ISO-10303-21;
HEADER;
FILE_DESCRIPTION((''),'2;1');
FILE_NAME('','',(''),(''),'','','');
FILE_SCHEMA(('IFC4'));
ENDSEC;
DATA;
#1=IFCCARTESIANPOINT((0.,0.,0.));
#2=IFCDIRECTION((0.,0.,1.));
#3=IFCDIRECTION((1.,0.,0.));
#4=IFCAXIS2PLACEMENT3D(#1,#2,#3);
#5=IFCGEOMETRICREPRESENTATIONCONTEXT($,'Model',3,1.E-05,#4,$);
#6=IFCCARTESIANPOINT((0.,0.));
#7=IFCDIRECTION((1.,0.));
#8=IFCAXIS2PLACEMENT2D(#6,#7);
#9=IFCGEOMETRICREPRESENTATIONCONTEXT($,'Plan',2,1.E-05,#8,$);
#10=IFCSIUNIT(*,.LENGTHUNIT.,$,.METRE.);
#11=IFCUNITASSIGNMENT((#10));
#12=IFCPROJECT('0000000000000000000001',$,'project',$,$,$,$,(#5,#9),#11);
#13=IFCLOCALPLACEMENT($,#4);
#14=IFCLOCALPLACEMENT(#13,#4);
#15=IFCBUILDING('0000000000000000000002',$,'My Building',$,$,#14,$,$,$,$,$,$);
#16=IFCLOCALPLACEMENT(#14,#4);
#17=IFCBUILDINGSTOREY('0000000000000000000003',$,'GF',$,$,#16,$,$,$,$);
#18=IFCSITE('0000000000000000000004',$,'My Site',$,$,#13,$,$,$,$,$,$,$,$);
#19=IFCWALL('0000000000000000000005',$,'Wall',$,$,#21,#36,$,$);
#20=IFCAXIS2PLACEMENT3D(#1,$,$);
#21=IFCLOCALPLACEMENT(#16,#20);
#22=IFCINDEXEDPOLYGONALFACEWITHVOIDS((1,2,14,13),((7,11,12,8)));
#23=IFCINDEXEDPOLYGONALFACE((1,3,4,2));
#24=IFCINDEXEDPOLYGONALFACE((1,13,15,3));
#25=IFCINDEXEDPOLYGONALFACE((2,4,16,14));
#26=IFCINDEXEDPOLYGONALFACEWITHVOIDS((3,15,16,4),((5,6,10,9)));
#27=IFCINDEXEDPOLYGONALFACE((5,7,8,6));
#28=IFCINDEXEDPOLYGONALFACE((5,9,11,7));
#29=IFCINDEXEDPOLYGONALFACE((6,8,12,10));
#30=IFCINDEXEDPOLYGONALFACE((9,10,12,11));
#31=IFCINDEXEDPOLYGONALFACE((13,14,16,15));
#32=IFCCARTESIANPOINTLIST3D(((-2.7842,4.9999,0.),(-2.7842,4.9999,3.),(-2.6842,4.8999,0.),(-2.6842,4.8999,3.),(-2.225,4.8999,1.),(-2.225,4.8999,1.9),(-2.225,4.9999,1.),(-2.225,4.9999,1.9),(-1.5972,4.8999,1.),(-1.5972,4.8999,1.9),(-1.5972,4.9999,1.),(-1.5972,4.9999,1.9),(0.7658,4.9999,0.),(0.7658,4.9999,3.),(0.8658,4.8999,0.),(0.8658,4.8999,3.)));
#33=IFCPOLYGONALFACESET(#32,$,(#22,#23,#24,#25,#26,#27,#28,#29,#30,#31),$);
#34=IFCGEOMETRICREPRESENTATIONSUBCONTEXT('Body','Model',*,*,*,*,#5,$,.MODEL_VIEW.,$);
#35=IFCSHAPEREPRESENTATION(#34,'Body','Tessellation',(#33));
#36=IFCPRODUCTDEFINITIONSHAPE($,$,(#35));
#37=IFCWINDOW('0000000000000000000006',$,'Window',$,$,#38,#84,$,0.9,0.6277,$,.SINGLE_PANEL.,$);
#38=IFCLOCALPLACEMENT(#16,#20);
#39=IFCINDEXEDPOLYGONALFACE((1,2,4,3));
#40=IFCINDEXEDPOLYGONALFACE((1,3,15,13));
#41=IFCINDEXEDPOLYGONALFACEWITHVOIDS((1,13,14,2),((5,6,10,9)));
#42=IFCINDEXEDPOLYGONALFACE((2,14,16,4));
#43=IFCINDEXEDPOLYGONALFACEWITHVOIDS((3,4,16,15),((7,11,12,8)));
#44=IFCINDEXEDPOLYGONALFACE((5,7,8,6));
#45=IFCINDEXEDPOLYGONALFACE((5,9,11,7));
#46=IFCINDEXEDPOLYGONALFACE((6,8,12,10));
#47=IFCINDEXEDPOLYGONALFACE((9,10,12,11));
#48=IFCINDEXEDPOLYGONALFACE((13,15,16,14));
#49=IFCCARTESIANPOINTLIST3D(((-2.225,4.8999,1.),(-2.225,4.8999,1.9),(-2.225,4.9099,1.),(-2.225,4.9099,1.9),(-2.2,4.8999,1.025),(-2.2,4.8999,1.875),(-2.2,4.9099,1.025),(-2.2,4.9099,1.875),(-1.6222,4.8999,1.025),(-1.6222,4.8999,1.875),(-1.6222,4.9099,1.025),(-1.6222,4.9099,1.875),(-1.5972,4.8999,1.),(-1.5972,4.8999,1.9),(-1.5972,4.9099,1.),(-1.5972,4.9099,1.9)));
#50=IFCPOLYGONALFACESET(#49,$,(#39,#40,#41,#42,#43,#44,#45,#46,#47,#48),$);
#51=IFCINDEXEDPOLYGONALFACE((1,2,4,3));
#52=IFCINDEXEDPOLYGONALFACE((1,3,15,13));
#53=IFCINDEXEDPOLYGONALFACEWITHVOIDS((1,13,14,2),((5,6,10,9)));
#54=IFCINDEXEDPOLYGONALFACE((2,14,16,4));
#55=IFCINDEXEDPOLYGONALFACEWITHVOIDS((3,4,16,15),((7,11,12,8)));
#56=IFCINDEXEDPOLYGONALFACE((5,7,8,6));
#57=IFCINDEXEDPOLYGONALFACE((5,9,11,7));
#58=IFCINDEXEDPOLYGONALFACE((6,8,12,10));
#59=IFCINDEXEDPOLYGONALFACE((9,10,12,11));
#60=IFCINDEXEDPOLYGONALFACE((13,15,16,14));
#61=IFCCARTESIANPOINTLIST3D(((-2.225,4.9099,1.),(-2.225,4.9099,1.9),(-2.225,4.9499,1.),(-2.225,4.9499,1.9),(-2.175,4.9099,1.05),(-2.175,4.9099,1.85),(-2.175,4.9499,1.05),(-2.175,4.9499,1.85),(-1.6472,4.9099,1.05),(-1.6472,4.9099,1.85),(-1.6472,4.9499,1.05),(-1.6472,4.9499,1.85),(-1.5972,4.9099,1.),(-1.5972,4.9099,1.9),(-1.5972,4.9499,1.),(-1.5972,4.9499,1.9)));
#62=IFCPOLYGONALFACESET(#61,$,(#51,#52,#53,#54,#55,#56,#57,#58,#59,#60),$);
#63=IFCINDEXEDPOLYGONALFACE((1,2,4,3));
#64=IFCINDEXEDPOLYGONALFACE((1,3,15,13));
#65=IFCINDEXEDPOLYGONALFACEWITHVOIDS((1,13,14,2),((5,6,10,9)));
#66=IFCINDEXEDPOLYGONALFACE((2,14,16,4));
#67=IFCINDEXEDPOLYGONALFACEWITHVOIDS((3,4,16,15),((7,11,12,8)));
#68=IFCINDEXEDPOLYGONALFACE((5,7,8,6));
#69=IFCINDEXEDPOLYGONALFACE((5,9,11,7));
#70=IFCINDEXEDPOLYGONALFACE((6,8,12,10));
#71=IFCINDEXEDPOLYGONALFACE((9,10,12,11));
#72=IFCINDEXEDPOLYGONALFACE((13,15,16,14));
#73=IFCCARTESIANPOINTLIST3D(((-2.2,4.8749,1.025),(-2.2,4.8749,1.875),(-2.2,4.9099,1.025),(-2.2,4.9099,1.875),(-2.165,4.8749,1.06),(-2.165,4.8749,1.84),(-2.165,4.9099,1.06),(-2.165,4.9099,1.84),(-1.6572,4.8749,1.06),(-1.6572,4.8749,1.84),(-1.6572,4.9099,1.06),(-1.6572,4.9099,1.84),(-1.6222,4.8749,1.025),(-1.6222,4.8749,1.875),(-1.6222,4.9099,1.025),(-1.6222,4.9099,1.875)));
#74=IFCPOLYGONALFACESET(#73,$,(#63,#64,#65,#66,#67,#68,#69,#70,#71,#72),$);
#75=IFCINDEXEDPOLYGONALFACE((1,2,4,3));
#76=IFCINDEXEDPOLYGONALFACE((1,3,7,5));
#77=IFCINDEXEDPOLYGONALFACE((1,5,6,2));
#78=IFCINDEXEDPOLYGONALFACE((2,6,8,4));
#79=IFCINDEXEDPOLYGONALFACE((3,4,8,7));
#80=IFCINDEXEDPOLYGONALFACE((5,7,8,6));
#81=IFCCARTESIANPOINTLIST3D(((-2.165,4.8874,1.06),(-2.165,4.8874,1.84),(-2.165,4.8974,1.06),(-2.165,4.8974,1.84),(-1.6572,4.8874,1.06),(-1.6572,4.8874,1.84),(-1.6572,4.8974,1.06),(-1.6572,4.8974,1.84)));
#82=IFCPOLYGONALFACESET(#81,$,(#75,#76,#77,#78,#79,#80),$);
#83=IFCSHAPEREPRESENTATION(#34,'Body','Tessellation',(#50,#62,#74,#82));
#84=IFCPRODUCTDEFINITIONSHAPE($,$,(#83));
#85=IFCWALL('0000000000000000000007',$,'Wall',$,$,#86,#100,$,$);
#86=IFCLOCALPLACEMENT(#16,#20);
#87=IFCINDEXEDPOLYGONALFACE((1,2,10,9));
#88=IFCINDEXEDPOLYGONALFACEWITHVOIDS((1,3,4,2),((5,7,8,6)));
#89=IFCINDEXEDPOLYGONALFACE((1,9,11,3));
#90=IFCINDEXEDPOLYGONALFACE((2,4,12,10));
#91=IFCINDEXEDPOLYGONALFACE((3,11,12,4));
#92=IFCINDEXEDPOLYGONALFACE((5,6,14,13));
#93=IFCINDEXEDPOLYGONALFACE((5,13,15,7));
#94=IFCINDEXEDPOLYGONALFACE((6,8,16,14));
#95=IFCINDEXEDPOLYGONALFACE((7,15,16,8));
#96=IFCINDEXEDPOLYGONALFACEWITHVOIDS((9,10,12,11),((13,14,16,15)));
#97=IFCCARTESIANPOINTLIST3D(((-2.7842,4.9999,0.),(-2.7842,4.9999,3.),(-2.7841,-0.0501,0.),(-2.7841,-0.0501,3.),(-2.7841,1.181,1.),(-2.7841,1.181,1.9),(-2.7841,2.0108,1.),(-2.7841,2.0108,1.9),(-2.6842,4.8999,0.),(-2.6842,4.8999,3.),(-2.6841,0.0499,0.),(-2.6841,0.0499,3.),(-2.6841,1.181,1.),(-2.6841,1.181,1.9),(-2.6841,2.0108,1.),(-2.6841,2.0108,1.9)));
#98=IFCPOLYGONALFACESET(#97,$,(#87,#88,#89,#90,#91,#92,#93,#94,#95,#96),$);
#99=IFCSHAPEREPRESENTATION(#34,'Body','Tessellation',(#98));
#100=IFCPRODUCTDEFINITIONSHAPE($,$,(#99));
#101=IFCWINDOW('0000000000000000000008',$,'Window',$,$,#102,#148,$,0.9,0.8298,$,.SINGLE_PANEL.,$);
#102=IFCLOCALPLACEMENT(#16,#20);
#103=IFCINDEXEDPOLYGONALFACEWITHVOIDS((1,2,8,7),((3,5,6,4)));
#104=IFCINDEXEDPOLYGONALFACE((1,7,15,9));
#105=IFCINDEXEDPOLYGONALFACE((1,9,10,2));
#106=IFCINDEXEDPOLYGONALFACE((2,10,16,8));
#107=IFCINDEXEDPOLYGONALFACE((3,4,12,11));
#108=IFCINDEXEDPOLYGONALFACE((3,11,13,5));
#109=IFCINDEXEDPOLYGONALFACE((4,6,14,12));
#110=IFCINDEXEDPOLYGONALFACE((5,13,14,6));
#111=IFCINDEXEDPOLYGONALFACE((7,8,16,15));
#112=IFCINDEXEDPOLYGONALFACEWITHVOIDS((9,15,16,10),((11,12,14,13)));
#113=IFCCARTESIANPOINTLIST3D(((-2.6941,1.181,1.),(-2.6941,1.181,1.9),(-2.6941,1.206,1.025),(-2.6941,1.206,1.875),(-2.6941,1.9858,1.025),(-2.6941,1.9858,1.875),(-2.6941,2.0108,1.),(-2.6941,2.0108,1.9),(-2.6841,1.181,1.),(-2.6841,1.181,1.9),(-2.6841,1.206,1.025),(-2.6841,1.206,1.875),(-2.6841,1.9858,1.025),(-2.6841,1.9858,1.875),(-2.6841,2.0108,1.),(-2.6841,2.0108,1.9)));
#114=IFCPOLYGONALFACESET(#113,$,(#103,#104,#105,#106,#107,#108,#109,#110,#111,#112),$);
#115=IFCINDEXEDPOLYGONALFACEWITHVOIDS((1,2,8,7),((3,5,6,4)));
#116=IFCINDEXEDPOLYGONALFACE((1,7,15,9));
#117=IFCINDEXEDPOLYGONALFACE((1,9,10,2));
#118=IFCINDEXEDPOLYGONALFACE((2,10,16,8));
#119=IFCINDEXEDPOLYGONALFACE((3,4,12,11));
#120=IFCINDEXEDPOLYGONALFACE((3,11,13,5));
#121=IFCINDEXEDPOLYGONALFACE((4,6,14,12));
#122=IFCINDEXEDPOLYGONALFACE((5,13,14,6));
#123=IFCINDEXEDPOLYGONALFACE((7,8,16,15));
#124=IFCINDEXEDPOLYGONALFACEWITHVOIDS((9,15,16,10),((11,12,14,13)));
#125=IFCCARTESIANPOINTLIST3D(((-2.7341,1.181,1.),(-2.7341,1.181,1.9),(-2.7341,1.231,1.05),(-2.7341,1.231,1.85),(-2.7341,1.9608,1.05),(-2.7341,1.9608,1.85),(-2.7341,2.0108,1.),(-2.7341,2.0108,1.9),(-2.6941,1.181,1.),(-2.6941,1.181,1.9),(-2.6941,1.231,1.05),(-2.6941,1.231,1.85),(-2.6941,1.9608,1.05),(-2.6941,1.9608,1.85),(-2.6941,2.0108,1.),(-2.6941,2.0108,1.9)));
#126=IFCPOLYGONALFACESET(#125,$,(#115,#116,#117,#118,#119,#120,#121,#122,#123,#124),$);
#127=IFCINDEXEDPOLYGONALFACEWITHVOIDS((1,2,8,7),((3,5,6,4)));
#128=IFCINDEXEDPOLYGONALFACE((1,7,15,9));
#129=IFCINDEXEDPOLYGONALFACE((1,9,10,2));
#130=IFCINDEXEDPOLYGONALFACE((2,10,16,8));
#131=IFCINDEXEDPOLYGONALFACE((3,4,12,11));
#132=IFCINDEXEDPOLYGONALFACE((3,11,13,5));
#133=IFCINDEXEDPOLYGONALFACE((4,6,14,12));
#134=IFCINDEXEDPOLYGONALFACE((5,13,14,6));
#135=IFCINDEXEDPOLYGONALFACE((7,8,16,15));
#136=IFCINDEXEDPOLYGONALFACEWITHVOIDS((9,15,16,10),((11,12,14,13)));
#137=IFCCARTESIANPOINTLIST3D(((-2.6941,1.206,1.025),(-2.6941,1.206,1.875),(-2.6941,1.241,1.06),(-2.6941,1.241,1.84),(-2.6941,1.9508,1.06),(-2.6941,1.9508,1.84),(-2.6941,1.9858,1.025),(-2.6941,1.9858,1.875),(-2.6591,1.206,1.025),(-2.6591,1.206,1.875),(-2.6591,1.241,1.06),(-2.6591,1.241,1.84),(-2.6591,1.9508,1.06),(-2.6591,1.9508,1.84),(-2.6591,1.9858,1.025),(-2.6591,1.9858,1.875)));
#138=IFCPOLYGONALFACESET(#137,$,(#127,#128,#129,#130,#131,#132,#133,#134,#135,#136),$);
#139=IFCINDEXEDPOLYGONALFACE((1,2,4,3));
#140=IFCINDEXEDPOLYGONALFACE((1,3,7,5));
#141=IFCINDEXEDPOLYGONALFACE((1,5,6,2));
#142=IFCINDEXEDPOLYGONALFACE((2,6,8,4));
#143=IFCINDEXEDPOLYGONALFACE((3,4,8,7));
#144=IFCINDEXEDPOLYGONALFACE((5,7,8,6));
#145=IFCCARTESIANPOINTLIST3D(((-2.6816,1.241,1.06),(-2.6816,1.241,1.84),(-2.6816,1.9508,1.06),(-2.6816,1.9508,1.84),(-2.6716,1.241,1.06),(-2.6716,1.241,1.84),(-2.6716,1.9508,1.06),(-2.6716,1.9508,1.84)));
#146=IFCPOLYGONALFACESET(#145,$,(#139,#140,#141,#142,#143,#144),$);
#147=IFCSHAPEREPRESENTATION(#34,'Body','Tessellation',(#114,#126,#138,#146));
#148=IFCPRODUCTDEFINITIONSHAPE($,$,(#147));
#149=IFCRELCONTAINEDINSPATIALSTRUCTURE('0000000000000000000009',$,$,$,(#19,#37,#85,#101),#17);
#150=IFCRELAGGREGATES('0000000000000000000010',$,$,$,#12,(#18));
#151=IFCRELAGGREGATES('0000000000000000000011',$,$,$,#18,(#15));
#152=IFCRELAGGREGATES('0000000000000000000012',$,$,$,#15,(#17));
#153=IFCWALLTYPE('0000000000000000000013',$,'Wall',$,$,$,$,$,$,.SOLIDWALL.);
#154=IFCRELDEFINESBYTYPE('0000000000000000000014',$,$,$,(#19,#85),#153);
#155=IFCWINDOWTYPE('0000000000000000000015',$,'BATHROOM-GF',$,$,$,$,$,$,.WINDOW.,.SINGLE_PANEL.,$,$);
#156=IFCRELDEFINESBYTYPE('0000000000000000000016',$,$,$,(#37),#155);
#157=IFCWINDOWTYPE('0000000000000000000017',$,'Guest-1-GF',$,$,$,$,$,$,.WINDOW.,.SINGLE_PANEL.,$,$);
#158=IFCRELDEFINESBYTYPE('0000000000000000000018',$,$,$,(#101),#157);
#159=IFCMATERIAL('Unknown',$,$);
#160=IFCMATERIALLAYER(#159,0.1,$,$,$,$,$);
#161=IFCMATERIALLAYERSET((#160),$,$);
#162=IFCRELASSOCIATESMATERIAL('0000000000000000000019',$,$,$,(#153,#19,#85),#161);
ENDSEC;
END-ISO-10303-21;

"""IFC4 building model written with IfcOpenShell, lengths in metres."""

from ifc_helpers import new_model, entity, si_unit, frame, origin_with_axes, origin_2d_with_axis, place, context, subcontext, project, spatial, line, indexed_curve, outline, extrude, shape, source, transform, mapped, material, layer, layer_set, layer_usage, type_object, type_shapes, element, fill, save


model = new_model("IFC4")

# Units and contexts
model_context = context("Model", 3, precision=1e-05, world=origin_with_axes())
plan_context = context("Plan", 2, precision=1e-05, world=origin_2d_with_axis())
body_context_1 = subcontext(model_context, "Body", "Model", "MODEL_VIEW")
body_context_2 = subcontext(plan_context, "Body", "Plan", "PLAN_VIEW")
ifc_project = project(units=[si_unit("LENGTHUNIT", "METRE")], contexts=[model_context, plan_context])

# Site, building, storey
site_placement = place(None, origin_with_axes())
site = spatial("IfcSite", under=ifc_project, at=site_placement, Name="My Site")
building_placement = place(site_placement, origin_with_axes())
building = spatial("IfcBuilding", under=site, at=building_placement, Name="My Building")
storey_placement = place(building_placement, origin_with_axes())
storey = spatial("IfcBuildingStorey", under=building, at=storey_placement, Name="GF")

# Shared definitions
ifc_material_1 = material(Name="Unknown")

# Shared definitions
ifc_layer_1 = layer(ifc_material_1, 0.1)
ifc_layer_set_1 = layer_set([ifc_layer_1])
wall_type = type_object("IfcWallType", Name="Wall", PredefinedType="SOLIDWALL", material=ifc_layer_set_1)

# Walls, openings, windows
ifc_layer_usage_1 = layer_usage(ifc_layer_set_1, "AXIS2", "POSITIVE", 0.0)
wall_1_placement = place(storey_placement, frame((0.7658, 4.9999, 0.0), z_axis=(0.0, 0.0, 1.0), x_axis=(-1.0, 0.0, 0.0)))
wall_1 = element("IfcWall", 1, at=wall_1_placement, inside=storey, type_object=wall_type, material=ifc_layer_usage_1, Name="Wall", context=body_context_1, shape_type="SweptSolid", body=[
    extrude(outline(indexed_curve([(0.0, 0.0), (-0.1, 0.1), (3.45, 0.1), (3.55, 0.0)], segments=[line(1, 2, 3, 4, 1)])), origin_with_axes(), (0.0, 0.0, 1.0), 3.0),
])
shared_shape_1 = source(origin_with_axes(), body_context_1, "Body", "SweptSolid", [
    extrude(outline(indexed_curve([(0.0, 0.0), (0.6277, 0.0), (0.6277, 0.9), (0.0, 0.9)], segments=[line(1, 2, 3, 4, 1)])), frame((0.0, -0.6, 0.0), z_axis=(0.0, -1.0, 0.0), x_axis=(1.0, 0.0, 0.0)), (0.0, 0.0, -1.0), 1.2),
])
opening_1_placement = place(wall_1_placement, frame((2.3631, 0.0, 1.0), z_axis=(0.0, 0.0, 1.0), x_axis=(1.0, 0.0, 0.0)))
opening_1 = element("IfcOpeningElement", 2, at=opening_1_placement, cuts=wall_1, PredefinedType="OPENING", context=body_context_1, shape_type="MappedRepresentation", body=[
    mapped(shared_shape_1, transform((0.0, 0.0, 0.0), x_axis=(1.0, 0.0, 0.0), y_axis=(0.0, 1.0, 0.0), z_axis=(0.0, 0.0, 1.0), scale=1.0)),
])
window_type_1 = type_object("IfcWindowType", Name="BATHROOM-GF", PartitioningType="SINGLE_PANEL", PredefinedType="WINDOW")
shared_shape_2 = source(origin_with_axes(), body_context_1, "Body", "SweptSolid", [
    extrude(outline(indexed_curve([(0.0, 0.0), (0.6277, 0.0), (0.6277, 0.9), (0.0, 0.9)], segments=[line(1, 2, 3, 4, 1)]), holes=[indexed_curve([(0.025, 0.025), (0.6027, 0.025), (0.6027, 0.875), (0.025, 0.875)], segments=[line(1, 2, 3, 4, 1)])]), frame((0.0, 0.09, 0.0), z_axis=(0.0, -1.0, 0.0), x_axis=(1.0, 0.0, 0.0)), (0.0, 0.0, -1.0), 0.01),
    extrude(outline(indexed_curve([(0.0, 0.0), (0.6277, 0.0), (0.6277, 0.9), (0.0, 0.9)], segments=[line(1, 2, 3, 4, 1)]), holes=[indexed_curve([(0.05, 0.05), (0.5777, 0.05), (0.5777, 0.85), (0.05, 0.85)], segments=[line(1, 2, 3, 4, 1)])]), frame((0.0, 0.05, 0.0), z_axis=(0.0, -1.0, 0.0), x_axis=(1.0, 0.0, 0.0)), (0.0, 0.0, -1.0), 0.04),
    extrude(outline(indexed_curve([(0.0, 0.0), (0.5777, 0.0), (0.5777, 0.85), (0.0, 0.85)], segments=[line(1, 2, 3, 4, 1)]), holes=[indexed_curve([(0.035, 0.035), (0.5427, 0.035), (0.5427, 0.815), (0.035, 0.815)], segments=[line(1, 2, 3, 4, 1)])]), frame((0.025, 0.09, 0.025), z_axis=(0.0, -1.0, 0.0), x_axis=(1.0, 0.0, 0.0)), (0.0, 0.0, -1.0), 0.035),
    extrude(outline(indexed_curve([(0.035, 0.035), (0.5427, 0.035), (0.5427, 0.815), (0.035, 0.815)], segments=[line(1, 2, 3, 4, 1)])), frame((0.025, 0.1025, 0.025), z_axis=(0.0, -1.0, 0.0), x_axis=(1.0, 0.0, 0.0)), (0.0, 0.0, -1.0), 0.01),
])
shared_shape_3 = source(origin_with_axes(), body_context_2, "Body", "Curve2D", [
    entity("IfcIndexedPolyCurve", entity("IfcCartesianPointList2D", [[0.05, 0.05], [0.5777, 0.05]])),
    entity("IfcIndexedPolyCurve", entity("IfcCartesianPointList2D", [[0.0, 0.1], [0.025, 0.1], [0.025, 0.09], [0.05, 0.09], [0.05, 0.05], [0.0, 0.05]]), [entity("IfcLineIndex", [1, 2, 3, 4, 5, 6, 1])]),
    entity("IfcIndexedPolyCurve", entity("IfcCartesianPointList2D", [[0.6277, 0.1], [0.6027, 0.1], [0.6027, 0.09], [0.5777, 0.09], [0.5777, 0.05], [0.6277, 0.05]]), [entity("IfcLineIndex", [1, 2, 3, 4, 5, 6, 1])]),
    entity("IfcIndexedPolyCurve", entity("IfcCartesianPointList2D", [[0.025, 0.09], [0.06, 0.09], [0.06, 0.125], [0.025, 0.125]]), [entity("IfcLineIndex", [1, 2, 3, 4, 1])]),
    entity("IfcIndexedPolyCurve", entity("IfcCartesianPointList2D", [[0.6027, 0.09], [0.5677, 0.09], [0.5677, 0.125], [0.6027, 0.125]]), [entity("IfcLineIndex", [1, 2, 3, 4, 1])]),
    entity("IfcIndexedPolyCurve", entity("IfcCartesianPointList2D", [[0.06, 0.09], [0.5677, 0.09]])),
    entity("IfcIndexedPolyCurve", entity("IfcCartesianPointList2D", [[0.06, 0.125], [0.5677, 0.125]])),
    entity("IfcIndexedPolyCurve", entity("IfcCartesianPointList2D", [[0.06, 0.1075], [0.5677, 0.1075]])),
])
type_shapes(window_type_1, [shared_shape_2, shared_shape_3])
window_1_placement = place(opening_1_placement, frame((0.0, 0.0, 0.0), z_axis=(0.0, 0.0, 1.0), x_axis=(1.0, 0.0, 0.0)))
window_1 = element("IfcWindow", 3, at=window_1_placement, inside=storey, type_object=window_type_1, Name="Window", OverallHeight=0.9, OverallWidth=0.6277, PartitioningType="SINGLE_PANEL", shapes=[
    shape(body_context_1, "Body", "MappedRepresentation", [mapped(shared_shape_2, transform((0.0, 0.0, 0.0), x_axis=(1.0, 0.0, 0.0), y_axis=(0.0, 1.0, 0.0), z_axis=(0.0, 0.0, 1.0), scale=1.0))]),
    shape(body_context_2, "Body", "MappedRepresentation", [mapped(shared_shape_3, transform((0.0, 0.0, 0.0), x_axis=(1.0, 0.0, 0.0), y_axis=(0.0, 1.0, 0.0), z_axis=(0.0, 0.0, 1.0), scale=1.0))]),
])
fill(opening_1, window_1)
ifc_layer_usage_2 = layer_usage(ifc_layer_set_1, "AXIS2", "POSITIVE", 0.0)
wall_2_placement = place(storey_placement, frame((-2.7842, 4.9999, 0.0), z_axis=(0.0, 0.0, 1.0), x_axis=(0.0, -1.0, 0.0)))
wall_2 = element("IfcWall", 4, at=wall_2_placement, inside=storey, type_object=wall_type, material=ifc_layer_usage_2, Name="Wall", context=body_context_1, shape_type="SweptSolid", body=[
    extrude(outline(indexed_curve([(0.0, 0.0), (0.1, 0.1), (4.95, 0.1), (5.05, 0.0)], segments=[line(1, 2, 3, 4, 1)])), origin_with_axes(), (0.0, 0.0, 1.0), 3.0),
])
shared_shape_4 = source(origin_with_axes(), body_context_1, "Body", "SweptSolid", [
    extrude(outline(indexed_curve([(0.0, 0.0), (0.8298, 0.0), (0.8298, 0.9), (0.0, 0.9)], segments=[line(1, 2, 3, 4, 1)])), frame((0.0, -0.6, 0.0), z_axis=(0.0, -1.0, 0.0), x_axis=(1.0, 0.0, 0.0)), (0.0, 0.0, -1.0), 1.2),
])
opening_2_placement = place(wall_2_placement, frame((2.989, 0.0, 1.0), z_axis=(0.0, 0.0, 1.0), x_axis=(1.0, 0.0, 0.0)))
opening_2 = element("IfcOpeningElement", 5, at=opening_2_placement, cuts=wall_2, PredefinedType="OPENING", context=body_context_1, shape_type="MappedRepresentation", body=[
    mapped(shared_shape_4, transform((0.0, 0.0, 0.0), x_axis=(1.0, 0.0, 0.0), y_axis=(0.0, 1.0, 0.0), z_axis=(0.0, 0.0, 1.0), scale=1.0)),
])
window_type_2 = type_object("IfcWindowType", Name="Guest-1-GF", PartitioningType="SINGLE_PANEL", PredefinedType="WINDOW")
shared_shape_5 = source(origin_with_axes(), body_context_1, "Body", "SweptSolid", [
    extrude(outline(indexed_curve([(0.0, 0.0), (0.8298, 0.0), (0.8298, 0.9), (0.0, 0.9)], segments=[line(1, 2, 3, 4, 1)]), holes=[indexed_curve([(0.025, 0.025), (0.8048, 0.025), (0.8048, 0.875), (0.025, 0.875)], segments=[line(1, 2, 3, 4, 1)])]), frame((0.0, 0.09, 0.0), z_axis=(0.0, -1.0, 0.0), x_axis=(1.0, 0.0, 0.0)), (0.0, 0.0, -1.0), 0.01),
    extrude(outline(indexed_curve([(0.0, 0.0), (0.8298, 0.0), (0.8298, 0.9), (0.0, 0.9)], segments=[line(1, 2, 3, 4, 1)]), holes=[indexed_curve([(0.05, 0.05), (0.7798, 0.05), (0.7798, 0.85), (0.05, 0.85)], segments=[line(1, 2, 3, 4, 1)])]), frame((0.0, 0.05, 0.0), z_axis=(0.0, -1.0, 0.0), x_axis=(1.0, 0.0, 0.0)), (0.0, 0.0, -1.0), 0.04),
    extrude(outline(indexed_curve([(0.0, 0.0), (0.7798, 0.0), (0.7798, 0.85), (0.0, 0.85)], segments=[line(1, 2, 3, 4, 1)]), holes=[indexed_curve([(0.035, 0.035), (0.7448, 0.035), (0.7448, 0.815), (0.035, 0.815)], segments=[line(1, 2, 3, 4, 1)])]), frame((0.025, 0.09, 0.025), z_axis=(0.0, -1.0, 0.0), x_axis=(1.0, 0.0, 0.0)), (0.0, 0.0, -1.0), 0.035),
    extrude(outline(indexed_curve([(0.035, 0.035), (0.7448, 0.035), (0.7448, 0.815), (0.035, 0.815)], segments=[line(1, 2, 3, 4, 1)])), frame((0.025, 0.1025, 0.025), z_axis=(0.0, -1.0, 0.0), x_axis=(1.0, 0.0, 0.0)), (0.0, 0.0, -1.0), 0.01),
])
shared_shape_6 = source(origin_with_axes(), body_context_2, "Body", "Curve2D", [
    entity("IfcIndexedPolyCurve", entity("IfcCartesianPointList2D", [[0.05, 0.05], [0.7798, 0.05]])),
    entity("IfcIndexedPolyCurve", entity("IfcCartesianPointList2D", [[0.0, 0.1], [0.025, 0.1], [0.025, 0.09], [0.05, 0.09], [0.05, 0.05], [0.0, 0.05]]), [entity("IfcLineIndex", [1, 2, 3, 4, 5, 6, 1])]),
    entity("IfcIndexedPolyCurve", entity("IfcCartesianPointList2D", [[0.8298, 0.1], [0.8048, 0.1], [0.8048, 0.09], [0.7798, 0.09], [0.7798, 0.05], [0.8298, 0.05]]), [entity("IfcLineIndex", [1, 2, 3, 4, 5, 6, 1])]),
    entity("IfcIndexedPolyCurve", entity("IfcCartesianPointList2D", [[0.025, 0.09], [0.06, 0.09], [0.06, 0.125], [0.025, 0.125]]), [entity("IfcLineIndex", [1, 2, 3, 4, 1])]),
    entity("IfcIndexedPolyCurve", entity("IfcCartesianPointList2D", [[0.8048, 0.09], [0.7698, 0.09], [0.7698, 0.125], [0.8048, 0.125]]), [entity("IfcLineIndex", [1, 2, 3, 4, 1])]),
    entity("IfcIndexedPolyCurve", entity("IfcCartesianPointList2D", [[0.06, 0.09], [0.7698, 0.09]])),
    entity("IfcIndexedPolyCurve", entity("IfcCartesianPointList2D", [[0.06, 0.125], [0.7698, 0.125]])),
    entity("IfcIndexedPolyCurve", entity("IfcCartesianPointList2D", [[0.06, 0.1075], [0.7698, 0.1075]])),
])
type_shapes(window_type_2, [shared_shape_5, shared_shape_6])
window_2_placement = place(opening_2_placement, frame((0.0, 0.0, 0.0), z_axis=(0.0, 0.0, 1.0), x_axis=(1.0, 0.0, 0.0)))
window_2 = element("IfcWindow", 6, at=window_2_placement, inside=storey, type_object=window_type_2, Name="Window", OverallHeight=0.9, OverallWidth=0.8298, PartitioningType="SINGLE_PANEL", shapes=[
    shape(body_context_1, "Body", "MappedRepresentation", [mapped(shared_shape_5, transform((0.0, 0.0, 0.0), x_axis=(1.0, 0.0, 0.0), y_axis=(0.0, 1.0, 0.0), z_axis=(0.0, 0.0, 1.0), scale=1.0))]),
    shape(body_context_2, "Body", "MappedRepresentation", [mapped(shared_shape_6, transform((0.0, 0.0, 0.0), x_axis=(1.0, 0.0, 0.0), y_axis=(0.0, 1.0, 0.0), z_axis=(0.0, 0.0, 1.0), scale=1.0))]),
])
fill(opening_2, window_2)

save(model, "model.ifc")
